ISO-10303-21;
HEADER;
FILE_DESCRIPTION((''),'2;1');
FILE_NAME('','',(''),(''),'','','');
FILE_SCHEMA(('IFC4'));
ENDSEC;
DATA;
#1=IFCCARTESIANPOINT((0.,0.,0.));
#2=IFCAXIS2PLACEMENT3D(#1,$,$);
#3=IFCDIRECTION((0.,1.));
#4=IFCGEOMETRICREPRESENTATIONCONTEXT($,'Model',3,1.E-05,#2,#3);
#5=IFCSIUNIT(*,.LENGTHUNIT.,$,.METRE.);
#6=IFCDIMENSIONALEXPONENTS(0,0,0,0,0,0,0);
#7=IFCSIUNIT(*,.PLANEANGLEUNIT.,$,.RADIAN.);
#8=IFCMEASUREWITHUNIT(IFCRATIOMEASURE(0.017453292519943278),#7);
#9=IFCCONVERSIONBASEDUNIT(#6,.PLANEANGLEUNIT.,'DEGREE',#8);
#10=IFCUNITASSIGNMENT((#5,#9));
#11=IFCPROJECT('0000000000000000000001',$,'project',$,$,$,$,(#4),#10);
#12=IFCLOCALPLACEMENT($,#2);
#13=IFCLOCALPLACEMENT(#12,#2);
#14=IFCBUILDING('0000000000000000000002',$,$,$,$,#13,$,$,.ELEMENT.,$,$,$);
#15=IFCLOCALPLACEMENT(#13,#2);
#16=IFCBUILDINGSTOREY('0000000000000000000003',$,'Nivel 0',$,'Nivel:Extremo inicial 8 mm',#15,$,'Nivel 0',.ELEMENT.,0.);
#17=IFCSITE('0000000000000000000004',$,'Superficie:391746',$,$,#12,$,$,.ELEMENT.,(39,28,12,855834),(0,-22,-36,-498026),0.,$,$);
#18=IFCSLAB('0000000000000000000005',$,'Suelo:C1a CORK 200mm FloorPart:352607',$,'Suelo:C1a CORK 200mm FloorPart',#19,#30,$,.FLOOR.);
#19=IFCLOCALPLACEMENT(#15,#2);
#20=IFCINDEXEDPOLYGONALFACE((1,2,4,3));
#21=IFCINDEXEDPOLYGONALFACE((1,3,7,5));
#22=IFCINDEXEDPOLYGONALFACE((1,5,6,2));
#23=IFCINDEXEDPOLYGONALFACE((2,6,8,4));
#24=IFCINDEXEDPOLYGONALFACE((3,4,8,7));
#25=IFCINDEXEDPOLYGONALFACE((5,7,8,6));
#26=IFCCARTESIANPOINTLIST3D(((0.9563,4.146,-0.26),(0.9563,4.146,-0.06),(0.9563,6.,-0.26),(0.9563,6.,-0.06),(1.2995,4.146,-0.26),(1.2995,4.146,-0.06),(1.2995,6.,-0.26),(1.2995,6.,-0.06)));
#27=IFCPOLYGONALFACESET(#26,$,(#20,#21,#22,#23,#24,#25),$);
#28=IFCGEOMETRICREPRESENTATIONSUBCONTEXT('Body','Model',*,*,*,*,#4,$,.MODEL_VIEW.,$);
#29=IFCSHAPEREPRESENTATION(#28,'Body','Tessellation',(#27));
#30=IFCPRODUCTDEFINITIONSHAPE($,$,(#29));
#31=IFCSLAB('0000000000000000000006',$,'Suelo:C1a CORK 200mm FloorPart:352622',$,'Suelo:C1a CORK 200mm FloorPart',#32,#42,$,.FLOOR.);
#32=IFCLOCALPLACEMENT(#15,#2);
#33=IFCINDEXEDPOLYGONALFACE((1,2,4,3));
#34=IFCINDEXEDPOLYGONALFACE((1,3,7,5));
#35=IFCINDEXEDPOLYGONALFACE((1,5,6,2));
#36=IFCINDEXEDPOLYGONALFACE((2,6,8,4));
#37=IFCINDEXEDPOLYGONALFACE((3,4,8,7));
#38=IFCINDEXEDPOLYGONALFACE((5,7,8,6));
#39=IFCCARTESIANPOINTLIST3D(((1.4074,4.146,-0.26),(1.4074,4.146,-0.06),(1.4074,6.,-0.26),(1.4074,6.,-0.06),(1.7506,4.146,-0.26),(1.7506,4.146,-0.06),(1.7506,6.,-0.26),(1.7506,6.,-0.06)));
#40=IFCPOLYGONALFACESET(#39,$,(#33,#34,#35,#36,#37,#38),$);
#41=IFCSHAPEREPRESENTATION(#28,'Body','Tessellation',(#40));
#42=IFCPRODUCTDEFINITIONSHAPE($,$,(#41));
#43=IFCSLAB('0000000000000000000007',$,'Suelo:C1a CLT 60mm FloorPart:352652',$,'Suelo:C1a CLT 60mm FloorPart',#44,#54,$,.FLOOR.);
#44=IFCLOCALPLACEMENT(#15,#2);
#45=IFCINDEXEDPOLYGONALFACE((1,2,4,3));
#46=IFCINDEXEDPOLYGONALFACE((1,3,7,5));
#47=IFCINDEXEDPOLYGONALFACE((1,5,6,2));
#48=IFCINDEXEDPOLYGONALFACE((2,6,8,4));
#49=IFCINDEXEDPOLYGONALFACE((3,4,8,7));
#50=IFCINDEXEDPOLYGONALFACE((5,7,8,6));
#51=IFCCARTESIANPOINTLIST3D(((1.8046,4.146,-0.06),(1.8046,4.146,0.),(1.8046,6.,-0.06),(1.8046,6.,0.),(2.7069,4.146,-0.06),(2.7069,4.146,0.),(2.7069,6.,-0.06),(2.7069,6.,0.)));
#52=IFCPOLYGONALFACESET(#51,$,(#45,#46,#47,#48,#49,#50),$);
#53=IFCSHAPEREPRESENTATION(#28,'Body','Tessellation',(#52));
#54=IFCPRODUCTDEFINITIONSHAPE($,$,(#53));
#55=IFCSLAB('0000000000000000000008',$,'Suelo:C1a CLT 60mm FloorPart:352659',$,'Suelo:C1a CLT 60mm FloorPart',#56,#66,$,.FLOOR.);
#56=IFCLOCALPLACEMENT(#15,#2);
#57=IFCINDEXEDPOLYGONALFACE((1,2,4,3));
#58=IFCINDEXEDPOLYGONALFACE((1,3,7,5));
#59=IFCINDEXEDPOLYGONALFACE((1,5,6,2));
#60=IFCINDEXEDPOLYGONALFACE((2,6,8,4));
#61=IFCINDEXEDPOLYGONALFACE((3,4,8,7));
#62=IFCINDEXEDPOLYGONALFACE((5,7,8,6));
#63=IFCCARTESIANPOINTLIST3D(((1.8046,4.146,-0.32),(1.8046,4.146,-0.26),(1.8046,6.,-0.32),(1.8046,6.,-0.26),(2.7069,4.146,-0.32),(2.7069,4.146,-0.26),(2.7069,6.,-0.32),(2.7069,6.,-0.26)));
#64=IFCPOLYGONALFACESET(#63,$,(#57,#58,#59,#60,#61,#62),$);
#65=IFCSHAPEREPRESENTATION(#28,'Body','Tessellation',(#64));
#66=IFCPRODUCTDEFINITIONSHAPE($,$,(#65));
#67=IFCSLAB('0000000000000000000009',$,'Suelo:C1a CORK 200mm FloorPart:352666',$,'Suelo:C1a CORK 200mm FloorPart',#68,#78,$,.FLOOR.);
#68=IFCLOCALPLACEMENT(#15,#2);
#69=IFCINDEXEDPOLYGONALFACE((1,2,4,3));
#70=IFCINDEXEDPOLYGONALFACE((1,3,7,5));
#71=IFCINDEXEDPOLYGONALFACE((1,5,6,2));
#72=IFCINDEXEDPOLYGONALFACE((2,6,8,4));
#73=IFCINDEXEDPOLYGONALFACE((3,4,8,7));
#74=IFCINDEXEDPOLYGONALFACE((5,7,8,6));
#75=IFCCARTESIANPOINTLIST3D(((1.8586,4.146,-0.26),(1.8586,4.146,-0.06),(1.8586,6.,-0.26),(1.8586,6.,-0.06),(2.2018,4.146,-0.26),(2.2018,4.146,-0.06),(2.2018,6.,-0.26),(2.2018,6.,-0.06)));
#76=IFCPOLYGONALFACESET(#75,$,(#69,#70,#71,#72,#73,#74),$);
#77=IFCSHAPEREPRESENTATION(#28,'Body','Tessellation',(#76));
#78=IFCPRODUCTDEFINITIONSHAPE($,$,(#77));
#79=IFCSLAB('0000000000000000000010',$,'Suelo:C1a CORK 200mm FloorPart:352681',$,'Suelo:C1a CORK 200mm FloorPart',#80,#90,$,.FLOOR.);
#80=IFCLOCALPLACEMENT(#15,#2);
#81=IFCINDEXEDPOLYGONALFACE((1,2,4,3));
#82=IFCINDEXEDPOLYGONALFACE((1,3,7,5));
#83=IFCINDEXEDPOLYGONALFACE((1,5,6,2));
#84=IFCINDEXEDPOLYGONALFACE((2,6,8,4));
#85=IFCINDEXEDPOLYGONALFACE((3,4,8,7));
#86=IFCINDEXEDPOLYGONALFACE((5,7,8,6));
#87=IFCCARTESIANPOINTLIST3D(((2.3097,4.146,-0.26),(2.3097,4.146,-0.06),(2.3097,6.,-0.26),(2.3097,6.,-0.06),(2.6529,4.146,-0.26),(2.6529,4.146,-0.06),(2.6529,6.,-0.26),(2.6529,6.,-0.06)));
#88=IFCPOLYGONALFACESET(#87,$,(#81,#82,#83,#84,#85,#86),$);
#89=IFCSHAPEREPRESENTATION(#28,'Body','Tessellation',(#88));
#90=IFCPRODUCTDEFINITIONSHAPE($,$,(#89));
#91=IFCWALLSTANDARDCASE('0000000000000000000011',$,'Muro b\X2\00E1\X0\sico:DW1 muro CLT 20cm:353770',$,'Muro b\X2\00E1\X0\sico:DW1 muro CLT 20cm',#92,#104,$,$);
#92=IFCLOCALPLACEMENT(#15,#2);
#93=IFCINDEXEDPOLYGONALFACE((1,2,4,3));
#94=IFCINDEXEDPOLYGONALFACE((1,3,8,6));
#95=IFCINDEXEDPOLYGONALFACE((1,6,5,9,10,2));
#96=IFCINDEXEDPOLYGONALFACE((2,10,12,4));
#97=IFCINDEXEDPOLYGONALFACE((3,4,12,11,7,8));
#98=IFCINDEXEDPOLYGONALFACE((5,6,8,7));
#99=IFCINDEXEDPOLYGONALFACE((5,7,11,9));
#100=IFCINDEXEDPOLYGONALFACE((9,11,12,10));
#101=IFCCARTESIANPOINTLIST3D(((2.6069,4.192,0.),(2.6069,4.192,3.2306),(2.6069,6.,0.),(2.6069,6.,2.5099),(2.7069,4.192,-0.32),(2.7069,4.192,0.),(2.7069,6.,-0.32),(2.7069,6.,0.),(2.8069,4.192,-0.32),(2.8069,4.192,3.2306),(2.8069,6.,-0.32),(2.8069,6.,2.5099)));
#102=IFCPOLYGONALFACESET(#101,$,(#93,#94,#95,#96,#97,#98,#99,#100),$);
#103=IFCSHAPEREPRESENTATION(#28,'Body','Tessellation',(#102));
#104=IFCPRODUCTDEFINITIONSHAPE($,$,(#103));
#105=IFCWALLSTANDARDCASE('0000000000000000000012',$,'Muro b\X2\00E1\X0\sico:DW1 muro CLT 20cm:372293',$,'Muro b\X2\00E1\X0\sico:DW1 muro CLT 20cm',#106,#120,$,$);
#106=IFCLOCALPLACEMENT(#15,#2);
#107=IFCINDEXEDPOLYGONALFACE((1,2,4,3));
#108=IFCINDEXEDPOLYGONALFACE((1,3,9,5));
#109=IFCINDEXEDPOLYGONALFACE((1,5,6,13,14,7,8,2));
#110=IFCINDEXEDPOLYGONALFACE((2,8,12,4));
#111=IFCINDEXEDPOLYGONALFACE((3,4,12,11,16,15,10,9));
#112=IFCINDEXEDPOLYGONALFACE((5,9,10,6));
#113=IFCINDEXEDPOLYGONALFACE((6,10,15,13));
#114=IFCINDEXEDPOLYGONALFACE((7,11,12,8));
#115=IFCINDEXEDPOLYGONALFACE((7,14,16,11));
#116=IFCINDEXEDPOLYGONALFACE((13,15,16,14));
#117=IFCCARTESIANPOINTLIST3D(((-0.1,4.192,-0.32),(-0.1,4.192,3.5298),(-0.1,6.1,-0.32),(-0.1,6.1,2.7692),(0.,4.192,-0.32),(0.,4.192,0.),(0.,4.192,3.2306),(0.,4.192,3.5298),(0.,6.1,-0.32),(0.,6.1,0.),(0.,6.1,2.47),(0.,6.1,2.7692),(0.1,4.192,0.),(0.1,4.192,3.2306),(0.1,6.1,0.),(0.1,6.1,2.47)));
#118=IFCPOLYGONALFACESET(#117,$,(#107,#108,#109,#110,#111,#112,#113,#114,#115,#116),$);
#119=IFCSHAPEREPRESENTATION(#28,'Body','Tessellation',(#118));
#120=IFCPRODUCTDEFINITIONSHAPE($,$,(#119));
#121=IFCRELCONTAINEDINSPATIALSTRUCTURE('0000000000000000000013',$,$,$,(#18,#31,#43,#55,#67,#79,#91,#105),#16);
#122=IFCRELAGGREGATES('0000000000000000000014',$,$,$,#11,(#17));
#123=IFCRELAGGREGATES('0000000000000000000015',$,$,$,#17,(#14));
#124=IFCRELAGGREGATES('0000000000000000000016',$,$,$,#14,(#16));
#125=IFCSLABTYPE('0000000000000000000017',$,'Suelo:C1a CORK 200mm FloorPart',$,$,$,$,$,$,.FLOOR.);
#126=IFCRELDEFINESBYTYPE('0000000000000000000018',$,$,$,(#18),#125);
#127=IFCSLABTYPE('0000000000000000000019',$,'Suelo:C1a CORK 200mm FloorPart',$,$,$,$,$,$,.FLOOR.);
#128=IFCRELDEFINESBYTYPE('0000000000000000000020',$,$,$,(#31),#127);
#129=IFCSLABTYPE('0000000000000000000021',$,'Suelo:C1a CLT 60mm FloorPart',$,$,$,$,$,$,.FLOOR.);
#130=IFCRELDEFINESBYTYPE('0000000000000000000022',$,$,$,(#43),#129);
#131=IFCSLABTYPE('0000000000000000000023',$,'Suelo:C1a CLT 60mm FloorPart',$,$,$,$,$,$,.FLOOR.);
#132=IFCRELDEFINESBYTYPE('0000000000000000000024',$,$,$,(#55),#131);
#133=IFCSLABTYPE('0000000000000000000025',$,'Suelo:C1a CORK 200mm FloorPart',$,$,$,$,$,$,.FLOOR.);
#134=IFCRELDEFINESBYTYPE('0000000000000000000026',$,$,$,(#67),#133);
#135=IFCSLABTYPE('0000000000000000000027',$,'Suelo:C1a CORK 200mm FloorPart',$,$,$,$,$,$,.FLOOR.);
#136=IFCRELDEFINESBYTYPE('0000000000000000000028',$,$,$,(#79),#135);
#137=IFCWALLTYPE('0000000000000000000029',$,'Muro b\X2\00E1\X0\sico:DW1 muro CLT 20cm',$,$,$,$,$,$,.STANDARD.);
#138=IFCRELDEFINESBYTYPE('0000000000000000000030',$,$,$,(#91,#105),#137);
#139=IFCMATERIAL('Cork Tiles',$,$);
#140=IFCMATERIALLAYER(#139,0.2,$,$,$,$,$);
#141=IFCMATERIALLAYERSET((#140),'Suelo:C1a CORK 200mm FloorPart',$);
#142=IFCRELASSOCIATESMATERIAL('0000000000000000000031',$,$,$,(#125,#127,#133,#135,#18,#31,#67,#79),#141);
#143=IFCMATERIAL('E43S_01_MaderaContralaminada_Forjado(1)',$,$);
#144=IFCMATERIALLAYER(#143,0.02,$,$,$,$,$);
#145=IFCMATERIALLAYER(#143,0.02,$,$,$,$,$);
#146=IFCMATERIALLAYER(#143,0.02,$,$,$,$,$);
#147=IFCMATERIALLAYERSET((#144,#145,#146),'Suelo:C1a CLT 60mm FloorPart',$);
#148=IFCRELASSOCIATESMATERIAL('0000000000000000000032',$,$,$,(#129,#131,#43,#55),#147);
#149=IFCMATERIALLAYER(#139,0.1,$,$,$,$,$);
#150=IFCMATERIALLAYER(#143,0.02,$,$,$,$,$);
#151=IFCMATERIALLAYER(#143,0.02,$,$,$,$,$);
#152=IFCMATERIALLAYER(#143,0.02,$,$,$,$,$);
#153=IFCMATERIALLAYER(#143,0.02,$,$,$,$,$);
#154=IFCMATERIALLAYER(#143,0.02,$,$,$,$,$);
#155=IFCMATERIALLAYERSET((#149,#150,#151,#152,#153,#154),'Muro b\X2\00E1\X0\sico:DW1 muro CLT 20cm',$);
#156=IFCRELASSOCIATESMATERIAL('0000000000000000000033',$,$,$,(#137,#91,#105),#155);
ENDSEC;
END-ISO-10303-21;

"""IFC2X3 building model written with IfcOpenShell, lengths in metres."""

from ifc_helpers import new_model, entity, si_unit, converted_unit, direction, frame, frame_2d, origin, origin_2d_with_axis, place, context, subcontext, project, spatial, polyline, rectangle, extrude, clip, bounded_halfspace, material, layer, layer_set, layer_usage, type_object, element, save


model = new_model("IFC2X3")

# Units and contexts
model_context = context("Model", 3, precision=1e-05, world=origin(), true_north=direction((0.0, 1.0)))
body_context = subcontext(model_context, "Body", "Model", "MODEL_VIEW")
ifc_project = project(units=[si_unit("LENGTHUNIT", "METRE"), converted_unit("PLANEANGLEUNIT", "DEGREE", entity("IfcRatioMeasure", 0.017453292519943278), si_unit("PLANEANGLEUNIT", "RADIAN"), dimensions=[0, 0, 0, 0, 0, 0, 0])], contexts=[model_context])

# Site, building, storey
site_placement = place(None, origin())
site = spatial("IfcSite", under=ifc_project, at=site_placement, Name="Superficie:391746", CompositionType="ELEMENT", RefLatitude=(39, 28, 12, 855834), RefLongitude=(0, -22, -36, -498026), RefElevation=0.0)
building_placement = place(site_placement, origin())
building = spatial("IfcBuilding", under=site, at=building_placement, CompositionType="ELEMENT")
storey_placement = place(building_placement, origin())
storey = spatial("IfcBuildingStorey", under=building, at=storey_placement, Name="Nivel 0", ObjectType="Nivel:Extremo inicial 8 mm", LongName="Nivel 0", CompositionType="ELEMENT", Elevation=0.0)

# Shared definitions
ifc_material_1 = material(Name="E43S_01_MaderaContralaminada_Forjado(1)")

# Slabs
ifc_layer_1 = layer(ifc_material_1, 0.02)
ifc_layer_2 = layer(ifc_material_1, 0.02)
ifc_layer_3 = layer(ifc_material_1, 0.02)
ifc_layer_set_1 = layer_set([ifc_layer_1, ifc_layer_2, ifc_layer_3], Name="Suelo:C1a CLT 60mm FloorPart")
ifc_material_2 = material(Name="Cork Tiles")
ifc_layer_4 = layer(ifc_material_2, 0.2)
ifc_layer_set_2 = layer_set([ifc_layer_4], Name="Suelo:C1a CORK 200mm FloorPart")
ifc_layer_usage_1 = layer_usage(ifc_layer_set_2, "AXIS3", "POSITIVE", 0.0)
slab_type_1 = type_object("IfcSlabType", Name="Suelo:C1a CORK 200mm FloorPart", PredefinedType="FLOOR", material=ifc_layer_set_2)
slab_1_placement = place(storey_placement, origin())
element("IfcSlab", 1, at=slab_1_placement, inside=storey, type_object=slab_type_1, material=ifc_layer_usage_1, Name="Suelo:C1a CORK 200mm FloorPart:352607", ObjectType="Suelo:C1a CORK 200mm FloorPart", PredefinedType="FLOOR", context=body_context, shape_type="SweptSolid", body=[
    extrude(rectangle(XDim=1.854, YDim=0.3432, at=frame_2d((0.0, 0.0), x_axis=(1.0, 0.0))), frame((1.1279, 5.073, -0.06), z_axis=(0.0, 0.0, -1.0), x_axis=(0.0, 1.0, 0.0)), (0.0, 0.0, 1.0), 0.2),
])
ifc_layer_usage_2 = layer_usage(ifc_layer_set_2, "AXIS3", "POSITIVE", 0.0)
slab_type_2 = type_object("IfcSlabType", Name="Suelo:C1a CORK 200mm FloorPart", PredefinedType="FLOOR", material=ifc_layer_set_2)
slab_2_placement = place(storey_placement, origin())
element("IfcSlab", 2, at=slab_2_placement, inside=storey, type_object=slab_type_2, material=ifc_layer_usage_2, Name="Suelo:C1a CORK 200mm FloorPart:352622", ObjectType="Suelo:C1a CORK 200mm FloorPart", PredefinedType="FLOOR", context=body_context, shape_type="SweptSolid", body=[
    extrude(rectangle(XDim=1.854, YDim=0.3432, at=frame_2d((0.0, 0.0), x_axis=(1.0, 0.0))), frame((1.579, 5.073, -0.06), z_axis=(0.0, 0.0, -1.0), x_axis=(0.0, 1.0, 0.0)), (0.0, 0.0, 1.0), 0.2),
])
ifc_layer_usage_3 = layer_usage(ifc_layer_set_1, "AXIS3", "POSITIVE", 0.0)
slab_type_3 = type_object("IfcSlabType", Name="Suelo:C1a CLT 60mm FloorPart", PredefinedType="FLOOR", material=ifc_layer_set_1)
slab_3_placement = place(storey_placement, origin())
element("IfcSlab", 3, at=slab_3_placement, inside=storey, type_object=slab_type_3, material=ifc_layer_usage_3, Name="Suelo:C1a CLT 60mm FloorPart:352652", ObjectType="Suelo:C1a CLT 60mm FloorPart", PredefinedType="FLOOR", context=body_context, shape_type="SweptSolid", body=[
    extrude(rectangle(XDim=1.854, YDim=0.9023, at=frame_2d((0.0, 0.0), x_axis=(1.0, 0.0))), frame((2.2558, 5.073, 0.0), z_axis=(0.0, 0.0, -1.0), x_axis=(0.0, 1.0, 0.0)), (0.0, 0.0, 1.0), 0.06),
])
ifc_layer_usage_4 = layer_usage(ifc_layer_set_1, "AXIS3", "POSITIVE", 0.0)
slab_type_4 = type_object("IfcSlabType", Name="Suelo:C1a CLT 60mm FloorPart", PredefinedType="FLOOR", material=ifc_layer_set_1)
slab_4_placement = place(storey_placement, origin())
element("IfcSlab", 4, at=slab_4_placement, inside=storey, type_object=slab_type_4, material=ifc_layer_usage_4, Name="Suelo:C1a CLT 60mm FloorPart:352659", ObjectType="Suelo:C1a CLT 60mm FloorPart", PredefinedType="FLOOR", context=body_context, shape_type="SweptSolid", body=[
    extrude(rectangle(XDim=1.854, YDim=0.9023, at=frame_2d((0.0, 0.0), x_axis=(1.0, 0.0))), frame((2.2558, 5.073, -0.26), z_axis=(0.0, 0.0, -1.0), x_axis=(0.0, 1.0, 0.0)), (0.0, 0.0, 1.0), 0.06),
])
ifc_layer_usage_5 = layer_usage(ifc_layer_set_2, "AXIS3", "POSITIVE", 0.0)
slab_type_5 = type_object("IfcSlabType", Name="Suelo:C1a CORK 200mm FloorPart", PredefinedType="FLOOR", material=ifc_layer_set_2)
slab_5_placement = place(storey_placement, origin())
element("IfcSlab", 5, at=slab_5_placement, inside=storey, type_object=slab_type_5, material=ifc_layer_usage_5, Name="Suelo:C1a CORK 200mm FloorPart:352666", ObjectType="Suelo:C1a CORK 200mm FloorPart", PredefinedType="FLOOR", context=body_context, shape_type="SweptSolid", body=[
    extrude(rectangle(XDim=1.854, YDim=0.3432, at=frame_2d((0.0, 0.0), x_axis=(1.0, 0.0))), frame((2.0302, 5.073, -0.06), z_axis=(0.0, 0.0, -1.0), x_axis=(0.0, 1.0, 0.0)), (0.0, 0.0, 1.0), 0.2),
])
ifc_layer_usage_6 = layer_usage(ifc_layer_set_2, "AXIS3", "POSITIVE", 0.0)
slab_type_6 = type_object("IfcSlabType", Name="Suelo:C1a CORK 200mm FloorPart", PredefinedType="FLOOR", material=ifc_layer_set_2)
slab_6_placement = place(storey_placement, origin())
element("IfcSlab", 6, at=slab_6_placement, inside=storey, type_object=slab_type_6, material=ifc_layer_usage_6, Name="Suelo:C1a CORK 200mm FloorPart:352681", ObjectType="Suelo:C1a CORK 200mm FloorPart", PredefinedType="FLOOR", context=body_context, shape_type="SweptSolid", body=[
    extrude(rectangle(XDim=1.854, YDim=0.3432, at=origin_2d_with_axis()), frame((2.4813, 5.073, -0.06), z_axis=(0.0, 0.0, -1.0), x_axis=(0.0, 1.0, 0.0)), (0.0, 0.0, 1.0), 0.2),
])

# Walls
ifc_layer_5 = layer(ifc_material_2, 0.1)
ifc_layer_6 = layer(ifc_material_1, 0.02)
ifc_layer_7 = layer(ifc_material_1, 0.02)
ifc_layer_8 = layer(ifc_material_1, 0.02)
ifc_layer_9 = layer(ifc_material_1, 0.02)
ifc_layer_10 = layer(ifc_material_1, 0.02)
ifc_layer_set_3 = layer_set([ifc_layer_5, ifc_layer_6, ifc_layer_7, ifc_layer_8, ifc_layer_9, ifc_layer_10], Name="Muro básico:DW1 muro CLT 20cm")
ifc_layer_usage_7 = layer_usage(ifc_layer_set_3, "AXIS2", "NEGATIVE", 0.1)
wall_type_1 = type_object("IfcWallType", Name="Muro básico:DW1 muro CLT 20cm", PredefinedType="STANDARD", material=ifc_layer_set_3)
wall_1_placement = place(storey_placement, frame((2.7069, 6.0, -0.32), z_axis=(0.0, 0.0, 1.0), x_axis=(0.0, -1.0, 0.0)))
element("IfcWallStandardCase", 7, at=wall_1_placement, inside=storey, type_object=wall_type_1, material=ifc_layer_usage_7, Name="Muro básico:DW1 muro CLT 20cm:353770", ObjectType="Muro básico:DW1 muro CLT 20cm", context=body_context, shape_type="Clipping", body=[
    clip(clip(extrude(rectangle(XDim=1.808, YDim=0.2, at=frame_2d((0.904, 0.0), x_axis=(-1.0, 0.0))), origin(), (0.0, 0.0, 1.0), 3.5506), bounded_halfspace(frame((0.0, -0.1, 2.8299), z_axis=(-0.370288, 0.0, 0.928917), x_axis=(0.0, -1.0, 0.0)), False, frame((0.0, -0.1, 2.8299)), polyline([(0.0, 0.0), (1.808, 0.0), (1.808, 0.2), (0.0, 0.2), (0.0, 0.0)]))), bounded_halfspace(frame((1.808, -0.1, 0.32), z_axis=(0.0, 0.0, -1.0), x_axis=(0.0, 1.0, 0.0)), False, frame((1.808, -0.1, 0.32)), polyline([(0.0, 0.0), (0.0, 0.1), (-0.1, 0.1), (-1.808, 0.1), (-1.808, 0.0), (-0.2, 0.0), (0.0, 0.0)]))),
])
ifc_layer_usage_8 = layer_usage(ifc_layer_set_3, "AXIS2", "NEGATIVE", 0.1)
wall_2_placement = place(storey_placement, frame((0.0, 4.192, -0.32), z_axis=(0.0, 0.0, 1.0), x_axis=(0.0, 1.0, 0.0)))
element("IfcWallStandardCase", 8, at=wall_2_placement, inside=storey, type_object=wall_type_1, material=ifc_layer_usage_8, Name="Muro básico:DW1 muro CLT 20cm:372293", ObjectType="Muro básico:DW1 muro CLT 20cm", context=body_context, shape_type="Clipping", body=[
    clip(clip(clip(extrude(rectangle(XDim=1.908, YDim=0.2, at=frame_2d((0.954, 0.0), x_axis=(-1.0, 0.0))), origin(), (0.0, 0.0, 1.0), 3.8498), bounded_halfspace(frame((0.0, -0.1, 3.5506), z_axis=(0.370288, 0.0, 0.928917), x_axis=(0.0, 1.0, 0.0)), False, frame((0.0, -0.1, 3.5506)), polyline([(0.0, 0.0), (1.708, 0.0), (1.908, 0.0), (1.908, 0.1), (0.0, 0.1), (0.0, 0.0)]))), bounded_halfspace(frame((1.908, 0.0, 3.0892), z_axis=(0.370288, 0.0, 0.928917), x_axis=(0.0, 1.0, 0.0)), False, frame((1.908, 0.0, 3.0892)), polyline([(0.0, 0.0), (0.0, 0.1), (-1.908, 0.1), (-1.908, 0.0), (0.0, 0.0)]))), bounded_halfspace(frame((1.908, -0.1, 0.32), z_axis=(0.0, 0.0, -1.0), x_axis=(0.0, 1.0, 0.0)), False, frame((1.908, -0.1, 0.32)), polyline([(0.0, 0.0), (0.0, 0.1), (-1.808, 0.1), (-1.908, 0.1), (-1.908, 0.0), (-1.708, 0.0), (-0.2, 0.0), (-0.1, 0.0), (0.0, 0.0)]))),
])

save(model, "model.ifc")
